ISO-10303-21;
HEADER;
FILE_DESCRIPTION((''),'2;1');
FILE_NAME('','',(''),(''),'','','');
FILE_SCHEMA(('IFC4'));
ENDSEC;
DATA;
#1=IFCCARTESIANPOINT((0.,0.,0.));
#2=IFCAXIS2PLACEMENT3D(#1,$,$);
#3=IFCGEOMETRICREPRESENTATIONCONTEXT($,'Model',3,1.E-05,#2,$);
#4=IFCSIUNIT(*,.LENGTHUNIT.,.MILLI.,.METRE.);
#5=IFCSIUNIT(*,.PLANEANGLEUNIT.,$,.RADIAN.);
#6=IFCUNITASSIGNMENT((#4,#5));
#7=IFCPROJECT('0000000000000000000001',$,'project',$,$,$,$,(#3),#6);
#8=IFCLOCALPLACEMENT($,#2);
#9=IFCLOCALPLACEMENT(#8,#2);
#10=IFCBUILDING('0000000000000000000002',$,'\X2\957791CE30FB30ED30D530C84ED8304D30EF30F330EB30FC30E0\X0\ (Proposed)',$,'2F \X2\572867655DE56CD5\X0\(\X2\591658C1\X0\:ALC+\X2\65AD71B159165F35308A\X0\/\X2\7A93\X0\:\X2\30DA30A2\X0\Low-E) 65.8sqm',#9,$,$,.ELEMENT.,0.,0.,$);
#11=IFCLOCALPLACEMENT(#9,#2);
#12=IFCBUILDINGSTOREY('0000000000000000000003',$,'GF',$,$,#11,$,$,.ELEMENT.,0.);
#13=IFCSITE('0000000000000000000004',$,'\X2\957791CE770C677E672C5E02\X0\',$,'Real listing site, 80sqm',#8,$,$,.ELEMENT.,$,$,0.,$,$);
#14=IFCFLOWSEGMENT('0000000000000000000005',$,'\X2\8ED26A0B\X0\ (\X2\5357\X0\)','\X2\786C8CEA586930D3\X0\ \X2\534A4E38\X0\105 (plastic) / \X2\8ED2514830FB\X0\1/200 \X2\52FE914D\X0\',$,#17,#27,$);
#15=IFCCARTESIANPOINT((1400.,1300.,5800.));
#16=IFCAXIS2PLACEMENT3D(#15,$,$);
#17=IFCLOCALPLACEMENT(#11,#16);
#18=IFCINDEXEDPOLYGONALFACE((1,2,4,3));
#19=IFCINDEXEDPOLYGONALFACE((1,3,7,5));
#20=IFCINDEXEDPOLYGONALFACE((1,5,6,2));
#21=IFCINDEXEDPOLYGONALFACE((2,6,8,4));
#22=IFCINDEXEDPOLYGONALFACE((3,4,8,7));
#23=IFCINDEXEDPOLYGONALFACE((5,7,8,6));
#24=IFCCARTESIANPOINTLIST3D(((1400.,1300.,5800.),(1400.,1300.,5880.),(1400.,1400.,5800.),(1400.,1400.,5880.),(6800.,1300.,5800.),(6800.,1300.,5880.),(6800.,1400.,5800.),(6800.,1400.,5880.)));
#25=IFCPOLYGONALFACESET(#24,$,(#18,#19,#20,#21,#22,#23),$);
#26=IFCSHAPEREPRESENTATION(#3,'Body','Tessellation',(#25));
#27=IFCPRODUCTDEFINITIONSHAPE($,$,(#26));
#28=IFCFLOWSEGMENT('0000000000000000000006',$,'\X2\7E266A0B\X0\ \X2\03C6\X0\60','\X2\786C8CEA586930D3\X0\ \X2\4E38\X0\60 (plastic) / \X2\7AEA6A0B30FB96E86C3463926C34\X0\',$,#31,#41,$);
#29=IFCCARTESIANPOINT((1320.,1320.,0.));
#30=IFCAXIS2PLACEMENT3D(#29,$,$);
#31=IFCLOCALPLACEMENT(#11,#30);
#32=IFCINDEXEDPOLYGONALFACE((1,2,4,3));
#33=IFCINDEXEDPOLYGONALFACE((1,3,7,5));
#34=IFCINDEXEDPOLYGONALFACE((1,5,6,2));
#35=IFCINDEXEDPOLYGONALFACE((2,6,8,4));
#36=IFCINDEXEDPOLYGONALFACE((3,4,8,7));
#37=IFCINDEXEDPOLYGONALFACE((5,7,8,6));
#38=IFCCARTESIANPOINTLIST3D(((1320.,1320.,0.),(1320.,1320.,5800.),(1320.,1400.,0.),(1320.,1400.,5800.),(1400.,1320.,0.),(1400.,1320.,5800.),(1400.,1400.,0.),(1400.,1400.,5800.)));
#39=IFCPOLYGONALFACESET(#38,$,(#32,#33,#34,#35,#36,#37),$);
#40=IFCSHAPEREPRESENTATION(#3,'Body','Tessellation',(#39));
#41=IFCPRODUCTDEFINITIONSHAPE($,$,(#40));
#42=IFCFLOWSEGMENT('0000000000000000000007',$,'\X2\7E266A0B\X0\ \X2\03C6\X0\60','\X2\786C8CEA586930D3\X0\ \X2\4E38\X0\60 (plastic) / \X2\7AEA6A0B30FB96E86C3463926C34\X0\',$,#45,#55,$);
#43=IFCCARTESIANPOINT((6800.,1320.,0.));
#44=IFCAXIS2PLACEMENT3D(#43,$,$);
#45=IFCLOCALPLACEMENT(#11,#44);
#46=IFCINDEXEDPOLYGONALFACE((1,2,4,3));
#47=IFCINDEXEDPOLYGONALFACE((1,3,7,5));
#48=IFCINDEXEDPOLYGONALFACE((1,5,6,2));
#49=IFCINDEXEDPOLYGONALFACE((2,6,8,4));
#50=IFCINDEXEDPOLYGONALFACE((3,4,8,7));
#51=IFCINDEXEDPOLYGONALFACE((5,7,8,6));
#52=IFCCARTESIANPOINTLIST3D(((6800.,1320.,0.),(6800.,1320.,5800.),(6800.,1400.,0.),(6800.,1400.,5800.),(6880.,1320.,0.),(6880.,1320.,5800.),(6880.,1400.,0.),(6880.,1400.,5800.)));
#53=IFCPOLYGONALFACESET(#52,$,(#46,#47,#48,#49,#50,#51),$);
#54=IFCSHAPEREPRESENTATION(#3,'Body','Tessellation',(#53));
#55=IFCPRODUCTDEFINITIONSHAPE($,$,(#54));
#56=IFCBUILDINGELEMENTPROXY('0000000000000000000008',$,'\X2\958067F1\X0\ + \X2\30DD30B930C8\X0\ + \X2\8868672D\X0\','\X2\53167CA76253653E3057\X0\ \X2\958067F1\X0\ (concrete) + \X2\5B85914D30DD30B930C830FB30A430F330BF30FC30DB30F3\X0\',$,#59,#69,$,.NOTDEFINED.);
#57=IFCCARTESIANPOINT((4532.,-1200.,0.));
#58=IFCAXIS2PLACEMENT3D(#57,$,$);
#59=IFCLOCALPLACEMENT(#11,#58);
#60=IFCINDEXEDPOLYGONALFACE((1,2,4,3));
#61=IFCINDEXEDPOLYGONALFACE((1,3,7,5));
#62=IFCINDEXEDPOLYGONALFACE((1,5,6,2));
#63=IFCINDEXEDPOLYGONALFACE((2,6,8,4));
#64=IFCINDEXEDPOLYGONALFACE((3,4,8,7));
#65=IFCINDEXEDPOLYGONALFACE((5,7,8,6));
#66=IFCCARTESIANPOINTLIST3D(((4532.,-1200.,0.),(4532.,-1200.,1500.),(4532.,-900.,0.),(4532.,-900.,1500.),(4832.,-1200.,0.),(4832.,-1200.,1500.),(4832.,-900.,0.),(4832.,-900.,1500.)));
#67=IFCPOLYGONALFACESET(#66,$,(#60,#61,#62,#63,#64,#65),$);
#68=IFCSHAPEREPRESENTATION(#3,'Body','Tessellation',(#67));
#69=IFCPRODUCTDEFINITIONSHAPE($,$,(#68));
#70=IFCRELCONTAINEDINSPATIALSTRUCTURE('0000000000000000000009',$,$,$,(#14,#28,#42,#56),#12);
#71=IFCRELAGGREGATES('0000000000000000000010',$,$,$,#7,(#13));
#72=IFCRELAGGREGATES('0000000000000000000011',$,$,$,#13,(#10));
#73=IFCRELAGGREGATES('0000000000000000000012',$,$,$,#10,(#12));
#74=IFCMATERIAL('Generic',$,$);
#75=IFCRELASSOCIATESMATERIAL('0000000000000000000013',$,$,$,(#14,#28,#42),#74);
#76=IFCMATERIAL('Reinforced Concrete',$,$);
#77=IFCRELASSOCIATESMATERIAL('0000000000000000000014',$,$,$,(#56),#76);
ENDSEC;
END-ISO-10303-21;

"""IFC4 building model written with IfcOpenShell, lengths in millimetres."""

from ifc_helpers import new_model, si_unit, frame, frame_2d, origin, place, context, project, spatial, rectangle, extrude, material, element, save


model = new_model("IFC4")

# Units and contexts
model_context = context("Model", 3, precision=1e-05, world=origin())
ifc_project = project(units=[si_unit("LENGTHUNIT", "METRE", prefix="MILLI"), si_unit("PLANEANGLEUNIT", "RADIAN")], contexts=[model_context])

# Site, building, storey
site_placement = place(None, origin())
site = spatial("IfcSite", under=ifc_project, at=site_placement, Name="長野県松本市", ObjectType="Real listing site, 80sqm", CompositionType="ELEMENT", RefElevation=0.0)
building_placement = place(site_placement, origin())
building = spatial("IfcBuilding", under=site, at=building_placement, Name="長野・ロフト付きワンルーム (Proposed)", ObjectType="2F 在来工法(外壁:ALC+断熱外張り/窓:ペアLow-E) 65.8sqm", CompositionType="ELEMENT", ElevationOfRefHeight=0.0, ElevationOfTerrain=0.0)
storey_placement = place(building_placement, origin())
storey = spatial("IfcBuildingStorey", under=building, at=storey_placement, Name="GF", CompositionType="ELEMENT", Elevation=0.0)

# Shared definitions
ifc_material_1 = material(Name="Reinforced Concrete")

# Flow segments
ifc_material_2 = material(Name="Generic")
flow_segment_1_placement = place(storey_placement, frame((1400.0, 1300.0, 5800.0)))
element("IfcFlowSegment", 1, at=flow_segment_1_placement, inside=storey, material=ifc_material_2, Name="軒樋 (南)", Description="硬質塩ビ 半丸105 (plastic) / 軒先・1/200 勾配", context=model_context, shape_type="SweptSolid", body=[
    extrude(rectangle(XDim=5400.0, YDim=100.0, at=frame_2d((2700.0, 50.0))), frame((1400.0, 1300.0, 5800.0)), (0.0, 0.0, 1.0), 80.0),
])
flow_segment_2_placement = place(storey_placement, frame((1320.0, 1320.0, 0.0)))
element("IfcFlowSegment", 2, at=flow_segment_2_placement, inside=storey, material=ifc_material_2, Name="縦樋 φ60", Description="硬質塩ビ 丸60 (plastic) / 竪樋・雨水排水", context=model_context, shape_type="SweptSolid", body=[
    extrude(rectangle(XDim=80.0, YDim=80.0, at=frame_2d((40.0, 40.0))), frame((1320.0, 1320.0, 0.0)), (0.0, 0.0, 1.0), 5800.0),
])
flow_segment_3_placement = place(storey_placement, frame((6800.0, 1320.0, 0.0)))
element("IfcFlowSegment", 3, at=flow_segment_3_placement, inside=storey, material=ifc_material_2, Name="縦樋 φ60", Description="硬質塩ビ 丸60 (plastic) / 竪樋・雨水排水", context=model_context, shape_type="SweptSolid", body=[
    extrude(rectangle(XDim=80.0, YDim=80.0, at=frame_2d((40.0, 40.0))), frame((6800.0, 1320.0, 0.0)), (0.0, 0.0, 1.0), 5800.0),
])

# Building element proxy
proxy_placement = place(storey_placement, frame((4532.0, -1200.0, 0.0)))
element("IfcBuildingElementProxy", 4, at=proxy_placement, inside=storey, material=ifc_material_1, Name="門柱 + ポスト + 表札", Description="化粧打放し 門柱 (concrete) + 宅配ポスト・インターホン", PredefinedType="NOTDEFINED", context=model_context, shape_type="SweptSolid", body=[
    extrude(rectangle(XDim=300.0, YDim=300.0, at=frame_2d((150.0, 150.0))), frame((4532.0, -1200.0, 0.0)), (0.0, 0.0, 1.0), 1500.0),
])

save(model, "model.ifc")
